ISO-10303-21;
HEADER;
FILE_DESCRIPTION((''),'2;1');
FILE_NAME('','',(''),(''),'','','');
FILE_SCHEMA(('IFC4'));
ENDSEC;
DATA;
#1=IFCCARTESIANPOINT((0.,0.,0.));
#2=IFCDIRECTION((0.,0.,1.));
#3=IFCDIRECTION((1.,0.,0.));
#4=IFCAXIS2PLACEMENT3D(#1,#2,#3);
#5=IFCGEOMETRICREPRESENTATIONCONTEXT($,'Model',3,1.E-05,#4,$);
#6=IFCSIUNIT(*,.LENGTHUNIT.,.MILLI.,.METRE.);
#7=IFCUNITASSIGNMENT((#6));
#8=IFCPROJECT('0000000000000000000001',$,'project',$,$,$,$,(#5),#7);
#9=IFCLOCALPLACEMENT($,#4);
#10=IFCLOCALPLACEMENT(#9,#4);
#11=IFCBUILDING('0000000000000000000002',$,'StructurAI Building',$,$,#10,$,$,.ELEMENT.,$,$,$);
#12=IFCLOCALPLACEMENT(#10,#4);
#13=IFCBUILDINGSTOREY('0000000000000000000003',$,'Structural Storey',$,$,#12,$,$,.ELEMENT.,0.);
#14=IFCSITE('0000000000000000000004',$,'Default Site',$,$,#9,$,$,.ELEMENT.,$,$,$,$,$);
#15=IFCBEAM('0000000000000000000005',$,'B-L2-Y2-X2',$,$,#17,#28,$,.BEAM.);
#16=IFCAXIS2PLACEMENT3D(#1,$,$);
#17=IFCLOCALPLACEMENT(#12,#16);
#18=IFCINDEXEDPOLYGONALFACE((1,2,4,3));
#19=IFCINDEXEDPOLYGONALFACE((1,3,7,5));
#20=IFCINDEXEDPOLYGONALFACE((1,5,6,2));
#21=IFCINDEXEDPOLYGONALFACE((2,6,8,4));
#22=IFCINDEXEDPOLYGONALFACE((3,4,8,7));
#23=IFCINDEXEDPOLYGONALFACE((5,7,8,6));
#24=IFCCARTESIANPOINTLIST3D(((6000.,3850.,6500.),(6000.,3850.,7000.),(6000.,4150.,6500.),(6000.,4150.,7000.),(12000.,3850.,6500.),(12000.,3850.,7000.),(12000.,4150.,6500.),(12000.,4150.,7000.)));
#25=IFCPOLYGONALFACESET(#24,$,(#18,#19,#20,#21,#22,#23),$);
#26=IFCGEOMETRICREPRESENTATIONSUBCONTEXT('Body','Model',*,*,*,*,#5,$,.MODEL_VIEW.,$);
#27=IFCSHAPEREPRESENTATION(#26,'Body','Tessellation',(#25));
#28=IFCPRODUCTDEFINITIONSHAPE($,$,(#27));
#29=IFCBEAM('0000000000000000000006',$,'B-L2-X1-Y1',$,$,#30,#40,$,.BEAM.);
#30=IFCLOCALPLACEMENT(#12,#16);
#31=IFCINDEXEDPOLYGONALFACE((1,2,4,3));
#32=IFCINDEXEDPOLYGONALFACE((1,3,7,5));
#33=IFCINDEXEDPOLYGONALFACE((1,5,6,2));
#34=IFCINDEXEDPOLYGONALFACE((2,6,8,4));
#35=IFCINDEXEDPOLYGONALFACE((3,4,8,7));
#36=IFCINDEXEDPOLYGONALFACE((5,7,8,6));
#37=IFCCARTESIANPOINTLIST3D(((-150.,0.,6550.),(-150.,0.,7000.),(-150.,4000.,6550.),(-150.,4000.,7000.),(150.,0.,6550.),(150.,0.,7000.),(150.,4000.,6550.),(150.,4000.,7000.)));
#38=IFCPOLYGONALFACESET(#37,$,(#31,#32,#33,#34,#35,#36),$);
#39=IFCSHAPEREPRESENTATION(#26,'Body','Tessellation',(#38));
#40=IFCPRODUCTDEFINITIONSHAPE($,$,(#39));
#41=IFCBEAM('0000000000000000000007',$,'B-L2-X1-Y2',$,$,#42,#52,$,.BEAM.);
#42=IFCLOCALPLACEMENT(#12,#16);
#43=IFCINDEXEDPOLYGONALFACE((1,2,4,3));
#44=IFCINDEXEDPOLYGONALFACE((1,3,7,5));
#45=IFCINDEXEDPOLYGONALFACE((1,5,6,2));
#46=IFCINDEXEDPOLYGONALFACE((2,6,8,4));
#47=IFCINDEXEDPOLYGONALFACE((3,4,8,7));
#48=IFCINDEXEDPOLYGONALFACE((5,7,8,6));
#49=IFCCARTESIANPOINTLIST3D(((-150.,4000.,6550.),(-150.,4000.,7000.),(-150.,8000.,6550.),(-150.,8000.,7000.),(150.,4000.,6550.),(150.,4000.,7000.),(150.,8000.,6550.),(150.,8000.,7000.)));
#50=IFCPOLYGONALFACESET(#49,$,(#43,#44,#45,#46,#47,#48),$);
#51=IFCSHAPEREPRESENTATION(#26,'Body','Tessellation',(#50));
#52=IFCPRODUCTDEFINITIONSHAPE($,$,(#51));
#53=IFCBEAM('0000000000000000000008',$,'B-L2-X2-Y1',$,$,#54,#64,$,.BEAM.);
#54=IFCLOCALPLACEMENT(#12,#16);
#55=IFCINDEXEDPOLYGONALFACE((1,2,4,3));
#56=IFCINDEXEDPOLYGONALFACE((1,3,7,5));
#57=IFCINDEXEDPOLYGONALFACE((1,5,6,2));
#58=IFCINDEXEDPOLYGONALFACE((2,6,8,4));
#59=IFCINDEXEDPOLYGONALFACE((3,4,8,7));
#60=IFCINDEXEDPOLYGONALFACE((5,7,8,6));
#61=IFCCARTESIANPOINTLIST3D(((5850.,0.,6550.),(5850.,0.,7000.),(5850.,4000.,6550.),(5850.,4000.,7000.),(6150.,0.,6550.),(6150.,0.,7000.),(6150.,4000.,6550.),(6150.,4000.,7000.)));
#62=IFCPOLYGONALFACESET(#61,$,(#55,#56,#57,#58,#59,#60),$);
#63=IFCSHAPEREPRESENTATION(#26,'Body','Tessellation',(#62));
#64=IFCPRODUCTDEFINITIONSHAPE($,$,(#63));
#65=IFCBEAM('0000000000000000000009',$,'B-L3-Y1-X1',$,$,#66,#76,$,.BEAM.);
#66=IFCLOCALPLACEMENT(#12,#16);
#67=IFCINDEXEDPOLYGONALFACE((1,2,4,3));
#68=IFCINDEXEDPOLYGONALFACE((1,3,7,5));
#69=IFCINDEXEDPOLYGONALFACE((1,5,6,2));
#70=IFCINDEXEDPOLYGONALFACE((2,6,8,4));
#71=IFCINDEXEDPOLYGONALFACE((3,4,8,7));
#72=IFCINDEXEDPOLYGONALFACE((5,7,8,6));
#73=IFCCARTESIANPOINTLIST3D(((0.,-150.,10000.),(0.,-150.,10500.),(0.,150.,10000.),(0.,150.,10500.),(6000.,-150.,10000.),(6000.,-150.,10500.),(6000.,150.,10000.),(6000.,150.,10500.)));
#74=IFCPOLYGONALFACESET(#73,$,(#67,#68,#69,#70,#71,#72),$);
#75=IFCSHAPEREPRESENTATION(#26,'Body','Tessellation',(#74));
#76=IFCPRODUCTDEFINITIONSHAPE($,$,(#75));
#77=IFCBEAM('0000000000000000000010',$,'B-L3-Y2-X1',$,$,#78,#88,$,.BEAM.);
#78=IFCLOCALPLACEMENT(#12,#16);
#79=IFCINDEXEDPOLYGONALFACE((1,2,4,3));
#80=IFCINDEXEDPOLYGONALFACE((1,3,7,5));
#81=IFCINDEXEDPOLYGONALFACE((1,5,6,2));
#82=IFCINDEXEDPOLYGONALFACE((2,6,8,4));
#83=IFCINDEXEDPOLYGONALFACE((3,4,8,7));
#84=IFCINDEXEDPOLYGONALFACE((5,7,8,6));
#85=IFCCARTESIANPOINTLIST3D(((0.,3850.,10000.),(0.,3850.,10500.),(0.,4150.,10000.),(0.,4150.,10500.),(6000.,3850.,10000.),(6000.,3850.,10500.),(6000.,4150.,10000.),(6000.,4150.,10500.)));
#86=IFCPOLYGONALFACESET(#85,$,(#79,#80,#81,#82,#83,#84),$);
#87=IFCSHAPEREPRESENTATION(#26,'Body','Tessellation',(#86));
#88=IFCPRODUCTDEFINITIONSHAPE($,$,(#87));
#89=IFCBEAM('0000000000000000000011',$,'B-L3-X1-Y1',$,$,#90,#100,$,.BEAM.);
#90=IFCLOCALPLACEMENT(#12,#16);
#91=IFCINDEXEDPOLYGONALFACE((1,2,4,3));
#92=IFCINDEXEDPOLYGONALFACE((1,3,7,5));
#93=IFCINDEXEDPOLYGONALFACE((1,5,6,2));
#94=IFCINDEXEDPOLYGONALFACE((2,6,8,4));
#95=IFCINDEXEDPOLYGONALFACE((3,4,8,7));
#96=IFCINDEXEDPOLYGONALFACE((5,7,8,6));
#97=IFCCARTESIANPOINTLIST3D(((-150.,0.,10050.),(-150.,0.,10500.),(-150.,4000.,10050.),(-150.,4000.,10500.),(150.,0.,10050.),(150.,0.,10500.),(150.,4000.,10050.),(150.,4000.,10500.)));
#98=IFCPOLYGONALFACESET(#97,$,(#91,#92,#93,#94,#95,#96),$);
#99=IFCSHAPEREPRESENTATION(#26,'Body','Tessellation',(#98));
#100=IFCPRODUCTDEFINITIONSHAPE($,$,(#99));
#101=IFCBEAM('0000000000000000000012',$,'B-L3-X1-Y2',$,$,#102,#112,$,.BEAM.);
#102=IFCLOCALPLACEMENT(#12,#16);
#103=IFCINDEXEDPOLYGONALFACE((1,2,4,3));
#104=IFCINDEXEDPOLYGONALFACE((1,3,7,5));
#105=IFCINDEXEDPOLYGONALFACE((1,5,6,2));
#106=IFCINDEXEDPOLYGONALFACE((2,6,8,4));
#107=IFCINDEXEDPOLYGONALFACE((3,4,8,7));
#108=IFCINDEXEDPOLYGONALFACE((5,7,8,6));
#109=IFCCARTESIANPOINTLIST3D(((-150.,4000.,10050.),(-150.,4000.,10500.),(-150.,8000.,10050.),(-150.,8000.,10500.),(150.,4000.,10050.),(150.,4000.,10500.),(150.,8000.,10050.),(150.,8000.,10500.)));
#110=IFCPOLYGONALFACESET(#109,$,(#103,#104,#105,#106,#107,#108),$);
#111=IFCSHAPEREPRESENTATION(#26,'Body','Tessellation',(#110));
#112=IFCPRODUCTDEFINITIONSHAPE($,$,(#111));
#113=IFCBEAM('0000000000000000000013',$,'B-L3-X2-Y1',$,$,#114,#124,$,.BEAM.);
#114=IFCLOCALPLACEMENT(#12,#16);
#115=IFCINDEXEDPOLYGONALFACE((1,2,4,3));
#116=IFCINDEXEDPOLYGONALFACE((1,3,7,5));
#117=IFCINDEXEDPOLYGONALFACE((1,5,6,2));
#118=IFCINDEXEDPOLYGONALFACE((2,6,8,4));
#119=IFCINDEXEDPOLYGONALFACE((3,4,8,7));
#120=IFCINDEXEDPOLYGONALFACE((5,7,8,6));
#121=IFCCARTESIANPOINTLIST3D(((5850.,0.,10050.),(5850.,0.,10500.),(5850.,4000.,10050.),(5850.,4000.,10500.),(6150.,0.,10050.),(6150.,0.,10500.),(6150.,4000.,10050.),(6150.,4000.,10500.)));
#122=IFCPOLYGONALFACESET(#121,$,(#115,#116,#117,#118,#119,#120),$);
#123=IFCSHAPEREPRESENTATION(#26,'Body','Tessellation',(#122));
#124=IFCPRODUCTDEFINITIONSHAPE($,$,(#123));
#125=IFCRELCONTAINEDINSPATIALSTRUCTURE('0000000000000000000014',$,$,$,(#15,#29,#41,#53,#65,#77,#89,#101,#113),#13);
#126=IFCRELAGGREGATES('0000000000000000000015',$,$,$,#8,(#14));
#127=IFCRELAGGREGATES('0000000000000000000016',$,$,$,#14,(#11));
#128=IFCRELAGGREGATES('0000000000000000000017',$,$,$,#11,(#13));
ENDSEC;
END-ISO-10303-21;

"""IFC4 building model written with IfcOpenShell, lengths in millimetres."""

from ifc_helpers import new_model, si_unit, frame, origin_with_axes, place, context, subcontext, project, spatial, rectangle, extrude, element, save


model = new_model("IFC4")

# Units and contexts
model_context = context("Model", 3, precision=1e-05, world=origin_with_axes())
body_context = subcontext(model_context, "Body", "Model", "MODEL_VIEW")
ifc_project = project(units=[si_unit("LENGTHUNIT", "METRE", prefix="MILLI")], contexts=[model_context])

# Site, building, storey
site_placement = place(None, origin_with_axes())
site = spatial("IfcSite", under=ifc_project, at=site_placement, Name="Default Site", CompositionType="ELEMENT")
building_placement = place(site_placement, origin_with_axes())
building = spatial("IfcBuilding", under=site, at=building_placement, Name="StructurAI Building", CompositionType="ELEMENT")
storey_placement = place(building_placement, origin_with_axes())
storey = spatial("IfcBuildingStorey", under=building, at=storey_placement, Name="Structural Storey", CompositionType="ELEMENT", Elevation=0.0)

# Beams
for number, where, z_axis, x_axis, name in (
    (1, (9000.0, 4000.0, 6500.0), (0.0, 0.0, 1.0), (1.0, 0.0, 0.0), "B-L2-Y2-X2"),
):
    element("IfcBeam", number, at=place(storey_placement, frame(where, z_axis=z_axis, x_axis=x_axis)), inside=storey, Name=name, PredefinedType="BEAM", context=body_context, shape_type="SweptSolid", body=[
        extrude(rectangle(XDim=6000.0, YDim=300.0), origin_with_axes(), (0.0, 0.0, 1.0), 500.0),
    ])
for number, where, z_axis, x_axis, name in (
    (2, (0.0, 2000.0, 6550.0), (0.0, 0.0, 1.0), (0.0, 1.0, 0.0), "B-L2-X1-Y1"),
    (3, (0.0, 6000.0, 6550.0), (0.0, 0.0, 1.0), (0.0, 1.0, 0.0), "B-L2-X1-Y2"),
    (4, (6000.0, 2000.0, 6550.0), (0.0, 0.0, 1.0), (0.0, 1.0, 0.0), "B-L2-X2-Y1"),
):
    element("IfcBeam", number, at=place(storey_placement, frame(where, z_axis=z_axis, x_axis=x_axis)), inside=storey, Name=name, PredefinedType="BEAM", context=body_context, shape_type="SweptSolid", body=[
        extrude(rectangle(XDim=4000.0, YDim=300.0), origin_with_axes(), (0.0, 0.0, 1.0), 450.0),
    ])
for number, where, z_axis, x_axis, name in (
    (5, (3000.0, 0.0, 10000.0), (0.0, 0.0, 1.0), (1.0, 0.0, 0.0), "B-L3-Y1-X1"),
    (6, (3000.0, 4000.0, 10000.0), (0.0, 0.0, 1.0), (1.0, 0.0, 0.0), "B-L3-Y2-X1"),
):
    element("IfcBeam", number, at=place(storey_placement, frame(where, z_axis=z_axis, x_axis=x_axis)), inside=storey, Name=name, PredefinedType="BEAM", context=body_context, shape_type="SweptSolid", body=[
        extrude(rectangle(XDim=6000.0, YDim=300.0), origin_with_axes(), (0.0, 0.0, 1.0), 500.0),
    ])
for number, where, z_axis, x_axis, name in (
    (7, (0.0, 2000.0, 10050.0), (0.0, 0.0, 1.0), (0.0, 1.0, 0.0), "B-L3-X1-Y1"),
    (8, (0.0, 6000.0, 10050.0), (0.0, 0.0, 1.0), (0.0, 1.0, 0.0), "B-L3-X1-Y2"),
    (9, (6000.0, 2000.0, 10050.0), (0.0, 0.0, 1.0), (0.0, 1.0, 0.0), "B-L3-X2-Y1"),
):
    element("IfcBeam", number, at=place(storey_placement, frame(where, z_axis=z_axis, x_axis=x_axis)), inside=storey, Name=name, PredefinedType="BEAM", context=body_context, shape_type="SweptSolid", body=[
        extrude(rectangle(XDim=4000.0, YDim=300.0), origin_with_axes(), (0.0, 0.0, 1.0), 450.0),
    ])

save(model, "model.ifc")
